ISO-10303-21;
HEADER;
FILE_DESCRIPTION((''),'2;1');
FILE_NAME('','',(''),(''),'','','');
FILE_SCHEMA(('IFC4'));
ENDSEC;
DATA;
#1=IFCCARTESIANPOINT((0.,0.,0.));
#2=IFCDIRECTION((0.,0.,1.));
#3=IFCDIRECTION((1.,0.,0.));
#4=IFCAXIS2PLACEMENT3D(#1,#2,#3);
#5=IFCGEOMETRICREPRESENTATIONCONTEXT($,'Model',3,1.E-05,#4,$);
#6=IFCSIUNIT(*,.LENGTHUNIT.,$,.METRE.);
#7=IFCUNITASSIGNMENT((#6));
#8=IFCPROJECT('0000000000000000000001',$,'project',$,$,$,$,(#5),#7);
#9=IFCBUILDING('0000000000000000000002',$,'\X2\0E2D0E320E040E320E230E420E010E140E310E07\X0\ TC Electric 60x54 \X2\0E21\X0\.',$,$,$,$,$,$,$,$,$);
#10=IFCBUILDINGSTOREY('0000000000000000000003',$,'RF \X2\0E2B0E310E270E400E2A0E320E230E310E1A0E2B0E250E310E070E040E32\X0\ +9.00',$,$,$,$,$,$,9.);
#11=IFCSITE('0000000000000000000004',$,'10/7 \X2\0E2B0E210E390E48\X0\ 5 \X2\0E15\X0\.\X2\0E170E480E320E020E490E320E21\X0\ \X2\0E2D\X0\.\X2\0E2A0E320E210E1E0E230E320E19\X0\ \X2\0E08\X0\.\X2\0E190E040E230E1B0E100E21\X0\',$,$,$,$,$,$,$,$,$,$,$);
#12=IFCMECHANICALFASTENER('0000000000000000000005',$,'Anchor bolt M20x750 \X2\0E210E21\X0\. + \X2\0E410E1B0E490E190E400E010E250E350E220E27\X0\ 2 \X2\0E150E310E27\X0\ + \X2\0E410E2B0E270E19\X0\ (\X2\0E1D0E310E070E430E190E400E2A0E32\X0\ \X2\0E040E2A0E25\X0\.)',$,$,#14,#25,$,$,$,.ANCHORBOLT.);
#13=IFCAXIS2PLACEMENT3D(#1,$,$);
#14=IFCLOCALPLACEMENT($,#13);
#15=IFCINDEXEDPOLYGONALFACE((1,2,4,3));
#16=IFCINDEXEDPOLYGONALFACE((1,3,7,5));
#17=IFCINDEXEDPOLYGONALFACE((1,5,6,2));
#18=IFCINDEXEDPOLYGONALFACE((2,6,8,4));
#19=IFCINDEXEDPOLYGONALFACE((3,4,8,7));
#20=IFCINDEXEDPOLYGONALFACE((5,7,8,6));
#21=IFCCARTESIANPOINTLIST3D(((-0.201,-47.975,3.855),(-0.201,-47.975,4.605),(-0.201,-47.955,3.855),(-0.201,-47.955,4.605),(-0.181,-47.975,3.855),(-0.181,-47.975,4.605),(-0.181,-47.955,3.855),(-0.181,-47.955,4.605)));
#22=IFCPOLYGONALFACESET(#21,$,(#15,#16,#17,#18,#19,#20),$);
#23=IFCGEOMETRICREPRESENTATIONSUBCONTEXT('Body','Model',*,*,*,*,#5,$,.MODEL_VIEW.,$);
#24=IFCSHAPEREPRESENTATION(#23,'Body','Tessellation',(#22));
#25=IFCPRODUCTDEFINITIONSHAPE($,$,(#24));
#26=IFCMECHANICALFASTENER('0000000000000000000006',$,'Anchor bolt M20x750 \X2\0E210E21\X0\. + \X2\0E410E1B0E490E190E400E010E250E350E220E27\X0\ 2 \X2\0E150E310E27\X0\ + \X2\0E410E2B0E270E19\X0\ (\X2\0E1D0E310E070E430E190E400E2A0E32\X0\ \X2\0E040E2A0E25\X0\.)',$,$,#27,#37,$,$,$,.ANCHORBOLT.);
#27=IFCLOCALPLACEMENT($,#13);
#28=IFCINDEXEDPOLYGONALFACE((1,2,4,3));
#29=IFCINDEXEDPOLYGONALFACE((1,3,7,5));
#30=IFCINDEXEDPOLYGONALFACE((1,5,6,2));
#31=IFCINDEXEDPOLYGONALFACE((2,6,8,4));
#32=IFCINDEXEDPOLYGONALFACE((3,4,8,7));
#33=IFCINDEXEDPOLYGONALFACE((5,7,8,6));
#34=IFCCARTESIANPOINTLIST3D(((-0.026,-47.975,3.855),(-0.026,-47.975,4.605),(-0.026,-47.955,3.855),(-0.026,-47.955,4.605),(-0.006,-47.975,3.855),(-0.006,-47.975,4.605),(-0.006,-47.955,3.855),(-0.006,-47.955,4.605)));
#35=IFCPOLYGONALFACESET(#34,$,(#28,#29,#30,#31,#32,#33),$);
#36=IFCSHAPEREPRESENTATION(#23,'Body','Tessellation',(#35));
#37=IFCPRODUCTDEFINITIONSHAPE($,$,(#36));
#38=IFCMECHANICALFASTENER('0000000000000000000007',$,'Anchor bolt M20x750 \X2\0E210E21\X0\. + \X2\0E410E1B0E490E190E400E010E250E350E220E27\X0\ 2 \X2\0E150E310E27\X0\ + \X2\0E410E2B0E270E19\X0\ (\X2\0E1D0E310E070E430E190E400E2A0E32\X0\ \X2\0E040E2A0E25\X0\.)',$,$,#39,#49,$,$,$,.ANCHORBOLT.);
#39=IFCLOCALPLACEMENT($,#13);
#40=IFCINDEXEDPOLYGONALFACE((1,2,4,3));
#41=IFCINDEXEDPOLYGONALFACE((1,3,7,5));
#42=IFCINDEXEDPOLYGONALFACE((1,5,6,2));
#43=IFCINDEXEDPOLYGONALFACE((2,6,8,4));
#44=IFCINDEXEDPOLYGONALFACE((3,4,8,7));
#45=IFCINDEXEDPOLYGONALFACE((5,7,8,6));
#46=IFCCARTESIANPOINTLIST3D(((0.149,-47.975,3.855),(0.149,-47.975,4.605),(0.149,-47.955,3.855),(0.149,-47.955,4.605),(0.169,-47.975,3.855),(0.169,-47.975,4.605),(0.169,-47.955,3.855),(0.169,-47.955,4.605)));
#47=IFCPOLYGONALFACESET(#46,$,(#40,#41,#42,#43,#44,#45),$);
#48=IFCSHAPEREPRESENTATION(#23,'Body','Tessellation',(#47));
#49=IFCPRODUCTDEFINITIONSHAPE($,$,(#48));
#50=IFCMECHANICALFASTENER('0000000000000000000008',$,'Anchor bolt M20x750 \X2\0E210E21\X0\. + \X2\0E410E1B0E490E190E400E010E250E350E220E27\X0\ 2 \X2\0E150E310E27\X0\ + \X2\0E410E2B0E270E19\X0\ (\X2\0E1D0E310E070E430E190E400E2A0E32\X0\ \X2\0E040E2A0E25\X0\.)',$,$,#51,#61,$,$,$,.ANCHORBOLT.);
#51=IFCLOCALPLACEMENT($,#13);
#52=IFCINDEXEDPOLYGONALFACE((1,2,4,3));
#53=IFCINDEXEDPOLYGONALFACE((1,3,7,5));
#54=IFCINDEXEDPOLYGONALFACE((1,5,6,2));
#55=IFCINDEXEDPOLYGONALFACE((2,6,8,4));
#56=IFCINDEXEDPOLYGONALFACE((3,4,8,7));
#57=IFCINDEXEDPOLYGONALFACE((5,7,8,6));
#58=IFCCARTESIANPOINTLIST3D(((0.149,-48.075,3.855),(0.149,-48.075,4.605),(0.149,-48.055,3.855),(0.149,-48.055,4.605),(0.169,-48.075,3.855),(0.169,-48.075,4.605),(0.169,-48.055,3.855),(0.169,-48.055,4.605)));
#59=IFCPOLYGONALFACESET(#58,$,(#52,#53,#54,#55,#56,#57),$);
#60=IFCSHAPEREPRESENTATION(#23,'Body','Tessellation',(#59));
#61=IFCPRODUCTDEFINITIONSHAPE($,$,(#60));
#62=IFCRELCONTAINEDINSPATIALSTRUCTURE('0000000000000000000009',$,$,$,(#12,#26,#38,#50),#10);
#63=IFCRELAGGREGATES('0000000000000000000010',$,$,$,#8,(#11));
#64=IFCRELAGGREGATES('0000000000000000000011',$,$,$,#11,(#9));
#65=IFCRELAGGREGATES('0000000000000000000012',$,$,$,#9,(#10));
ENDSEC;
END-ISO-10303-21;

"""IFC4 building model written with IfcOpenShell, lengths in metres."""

from ifc_helpers import new_model, si_unit, frame, origin, origin_with_axes, origin_2d, place, context, subcontext, project, spatial, rectangle, extrude, element, save


model = new_model("IFC4")

# Units and contexts
model_context = context("Model", 3, precision=1e-05, world=origin_with_axes())
body_context = subcontext(model_context, "Body", "Model", "MODEL_VIEW")
ifc_project = project(units=[si_unit("LENGTHUNIT", "METRE")], contexts=[model_context])

# Site, building, storey
site = spatial("IfcSite", under=ifc_project, Name="10/7 หมู่ 5 ต.ท่าข้าม อ.สามพราน จ.นครปฐม")
building = spatial("IfcBuilding", under=site, Name="อาคารโกดัง TC Electric 60x54 ม.")
storey = spatial("IfcBuildingStorey", under=building, Name="RF หัวเสารับหลังคา +9.00", Elevation=9.0)

# Mechanical fasteners
for number, where, z_axis, x_axis, name in (
    (1, (-0.191, -47.965, 3.855), (0.0, 0.0, 1.0), (1.0, 0.0, 0.0), "Anchor bolt M20x750 มม. + แป้นเกลียว 2 ตัว + แหวน (ฝังในเสา คสล.)"),
    (2, (-0.016, -47.965, 3.855), (0.0, 0.0, 1.0), (1.0, 0.0, 0.0), "Anchor bolt M20x750 มม. + แป้นเกลียว 2 ตัว + แหวน (ฝังในเสา คสล.)"),
    (3, (0.159, -47.965, 3.855), (0.0, 0.0, 1.0), (1.0, 0.0, 0.0), "Anchor bolt M20x750 มม. + แป้นเกลียว 2 ตัว + แหวน (ฝังในเสา คสล.)"),
    (4, (0.159, -48.065, 3.855), (0.0, 0.0, 1.0), (1.0, 0.0, 0.0), "Anchor bolt M20x750 มม. + แป้นเกลียว 2 ตัว + แหวน (ฝังในเสา คสล.)"),
):
    element("IfcMechanicalFastener", number, at=place(None, frame(where, z_axis=z_axis, x_axis=x_axis)), inside=storey, Name=name, PredefinedType="ANCHORBOLT", context=body_context, shape_type="SweptSolid", body=[
        extrude(rectangle(XDim=0.02, YDim=0.02, at=origin_2d()), origin(), (0.0, 0.0, 1.0), 0.75),
    ])

save(model, "model.ifc")
